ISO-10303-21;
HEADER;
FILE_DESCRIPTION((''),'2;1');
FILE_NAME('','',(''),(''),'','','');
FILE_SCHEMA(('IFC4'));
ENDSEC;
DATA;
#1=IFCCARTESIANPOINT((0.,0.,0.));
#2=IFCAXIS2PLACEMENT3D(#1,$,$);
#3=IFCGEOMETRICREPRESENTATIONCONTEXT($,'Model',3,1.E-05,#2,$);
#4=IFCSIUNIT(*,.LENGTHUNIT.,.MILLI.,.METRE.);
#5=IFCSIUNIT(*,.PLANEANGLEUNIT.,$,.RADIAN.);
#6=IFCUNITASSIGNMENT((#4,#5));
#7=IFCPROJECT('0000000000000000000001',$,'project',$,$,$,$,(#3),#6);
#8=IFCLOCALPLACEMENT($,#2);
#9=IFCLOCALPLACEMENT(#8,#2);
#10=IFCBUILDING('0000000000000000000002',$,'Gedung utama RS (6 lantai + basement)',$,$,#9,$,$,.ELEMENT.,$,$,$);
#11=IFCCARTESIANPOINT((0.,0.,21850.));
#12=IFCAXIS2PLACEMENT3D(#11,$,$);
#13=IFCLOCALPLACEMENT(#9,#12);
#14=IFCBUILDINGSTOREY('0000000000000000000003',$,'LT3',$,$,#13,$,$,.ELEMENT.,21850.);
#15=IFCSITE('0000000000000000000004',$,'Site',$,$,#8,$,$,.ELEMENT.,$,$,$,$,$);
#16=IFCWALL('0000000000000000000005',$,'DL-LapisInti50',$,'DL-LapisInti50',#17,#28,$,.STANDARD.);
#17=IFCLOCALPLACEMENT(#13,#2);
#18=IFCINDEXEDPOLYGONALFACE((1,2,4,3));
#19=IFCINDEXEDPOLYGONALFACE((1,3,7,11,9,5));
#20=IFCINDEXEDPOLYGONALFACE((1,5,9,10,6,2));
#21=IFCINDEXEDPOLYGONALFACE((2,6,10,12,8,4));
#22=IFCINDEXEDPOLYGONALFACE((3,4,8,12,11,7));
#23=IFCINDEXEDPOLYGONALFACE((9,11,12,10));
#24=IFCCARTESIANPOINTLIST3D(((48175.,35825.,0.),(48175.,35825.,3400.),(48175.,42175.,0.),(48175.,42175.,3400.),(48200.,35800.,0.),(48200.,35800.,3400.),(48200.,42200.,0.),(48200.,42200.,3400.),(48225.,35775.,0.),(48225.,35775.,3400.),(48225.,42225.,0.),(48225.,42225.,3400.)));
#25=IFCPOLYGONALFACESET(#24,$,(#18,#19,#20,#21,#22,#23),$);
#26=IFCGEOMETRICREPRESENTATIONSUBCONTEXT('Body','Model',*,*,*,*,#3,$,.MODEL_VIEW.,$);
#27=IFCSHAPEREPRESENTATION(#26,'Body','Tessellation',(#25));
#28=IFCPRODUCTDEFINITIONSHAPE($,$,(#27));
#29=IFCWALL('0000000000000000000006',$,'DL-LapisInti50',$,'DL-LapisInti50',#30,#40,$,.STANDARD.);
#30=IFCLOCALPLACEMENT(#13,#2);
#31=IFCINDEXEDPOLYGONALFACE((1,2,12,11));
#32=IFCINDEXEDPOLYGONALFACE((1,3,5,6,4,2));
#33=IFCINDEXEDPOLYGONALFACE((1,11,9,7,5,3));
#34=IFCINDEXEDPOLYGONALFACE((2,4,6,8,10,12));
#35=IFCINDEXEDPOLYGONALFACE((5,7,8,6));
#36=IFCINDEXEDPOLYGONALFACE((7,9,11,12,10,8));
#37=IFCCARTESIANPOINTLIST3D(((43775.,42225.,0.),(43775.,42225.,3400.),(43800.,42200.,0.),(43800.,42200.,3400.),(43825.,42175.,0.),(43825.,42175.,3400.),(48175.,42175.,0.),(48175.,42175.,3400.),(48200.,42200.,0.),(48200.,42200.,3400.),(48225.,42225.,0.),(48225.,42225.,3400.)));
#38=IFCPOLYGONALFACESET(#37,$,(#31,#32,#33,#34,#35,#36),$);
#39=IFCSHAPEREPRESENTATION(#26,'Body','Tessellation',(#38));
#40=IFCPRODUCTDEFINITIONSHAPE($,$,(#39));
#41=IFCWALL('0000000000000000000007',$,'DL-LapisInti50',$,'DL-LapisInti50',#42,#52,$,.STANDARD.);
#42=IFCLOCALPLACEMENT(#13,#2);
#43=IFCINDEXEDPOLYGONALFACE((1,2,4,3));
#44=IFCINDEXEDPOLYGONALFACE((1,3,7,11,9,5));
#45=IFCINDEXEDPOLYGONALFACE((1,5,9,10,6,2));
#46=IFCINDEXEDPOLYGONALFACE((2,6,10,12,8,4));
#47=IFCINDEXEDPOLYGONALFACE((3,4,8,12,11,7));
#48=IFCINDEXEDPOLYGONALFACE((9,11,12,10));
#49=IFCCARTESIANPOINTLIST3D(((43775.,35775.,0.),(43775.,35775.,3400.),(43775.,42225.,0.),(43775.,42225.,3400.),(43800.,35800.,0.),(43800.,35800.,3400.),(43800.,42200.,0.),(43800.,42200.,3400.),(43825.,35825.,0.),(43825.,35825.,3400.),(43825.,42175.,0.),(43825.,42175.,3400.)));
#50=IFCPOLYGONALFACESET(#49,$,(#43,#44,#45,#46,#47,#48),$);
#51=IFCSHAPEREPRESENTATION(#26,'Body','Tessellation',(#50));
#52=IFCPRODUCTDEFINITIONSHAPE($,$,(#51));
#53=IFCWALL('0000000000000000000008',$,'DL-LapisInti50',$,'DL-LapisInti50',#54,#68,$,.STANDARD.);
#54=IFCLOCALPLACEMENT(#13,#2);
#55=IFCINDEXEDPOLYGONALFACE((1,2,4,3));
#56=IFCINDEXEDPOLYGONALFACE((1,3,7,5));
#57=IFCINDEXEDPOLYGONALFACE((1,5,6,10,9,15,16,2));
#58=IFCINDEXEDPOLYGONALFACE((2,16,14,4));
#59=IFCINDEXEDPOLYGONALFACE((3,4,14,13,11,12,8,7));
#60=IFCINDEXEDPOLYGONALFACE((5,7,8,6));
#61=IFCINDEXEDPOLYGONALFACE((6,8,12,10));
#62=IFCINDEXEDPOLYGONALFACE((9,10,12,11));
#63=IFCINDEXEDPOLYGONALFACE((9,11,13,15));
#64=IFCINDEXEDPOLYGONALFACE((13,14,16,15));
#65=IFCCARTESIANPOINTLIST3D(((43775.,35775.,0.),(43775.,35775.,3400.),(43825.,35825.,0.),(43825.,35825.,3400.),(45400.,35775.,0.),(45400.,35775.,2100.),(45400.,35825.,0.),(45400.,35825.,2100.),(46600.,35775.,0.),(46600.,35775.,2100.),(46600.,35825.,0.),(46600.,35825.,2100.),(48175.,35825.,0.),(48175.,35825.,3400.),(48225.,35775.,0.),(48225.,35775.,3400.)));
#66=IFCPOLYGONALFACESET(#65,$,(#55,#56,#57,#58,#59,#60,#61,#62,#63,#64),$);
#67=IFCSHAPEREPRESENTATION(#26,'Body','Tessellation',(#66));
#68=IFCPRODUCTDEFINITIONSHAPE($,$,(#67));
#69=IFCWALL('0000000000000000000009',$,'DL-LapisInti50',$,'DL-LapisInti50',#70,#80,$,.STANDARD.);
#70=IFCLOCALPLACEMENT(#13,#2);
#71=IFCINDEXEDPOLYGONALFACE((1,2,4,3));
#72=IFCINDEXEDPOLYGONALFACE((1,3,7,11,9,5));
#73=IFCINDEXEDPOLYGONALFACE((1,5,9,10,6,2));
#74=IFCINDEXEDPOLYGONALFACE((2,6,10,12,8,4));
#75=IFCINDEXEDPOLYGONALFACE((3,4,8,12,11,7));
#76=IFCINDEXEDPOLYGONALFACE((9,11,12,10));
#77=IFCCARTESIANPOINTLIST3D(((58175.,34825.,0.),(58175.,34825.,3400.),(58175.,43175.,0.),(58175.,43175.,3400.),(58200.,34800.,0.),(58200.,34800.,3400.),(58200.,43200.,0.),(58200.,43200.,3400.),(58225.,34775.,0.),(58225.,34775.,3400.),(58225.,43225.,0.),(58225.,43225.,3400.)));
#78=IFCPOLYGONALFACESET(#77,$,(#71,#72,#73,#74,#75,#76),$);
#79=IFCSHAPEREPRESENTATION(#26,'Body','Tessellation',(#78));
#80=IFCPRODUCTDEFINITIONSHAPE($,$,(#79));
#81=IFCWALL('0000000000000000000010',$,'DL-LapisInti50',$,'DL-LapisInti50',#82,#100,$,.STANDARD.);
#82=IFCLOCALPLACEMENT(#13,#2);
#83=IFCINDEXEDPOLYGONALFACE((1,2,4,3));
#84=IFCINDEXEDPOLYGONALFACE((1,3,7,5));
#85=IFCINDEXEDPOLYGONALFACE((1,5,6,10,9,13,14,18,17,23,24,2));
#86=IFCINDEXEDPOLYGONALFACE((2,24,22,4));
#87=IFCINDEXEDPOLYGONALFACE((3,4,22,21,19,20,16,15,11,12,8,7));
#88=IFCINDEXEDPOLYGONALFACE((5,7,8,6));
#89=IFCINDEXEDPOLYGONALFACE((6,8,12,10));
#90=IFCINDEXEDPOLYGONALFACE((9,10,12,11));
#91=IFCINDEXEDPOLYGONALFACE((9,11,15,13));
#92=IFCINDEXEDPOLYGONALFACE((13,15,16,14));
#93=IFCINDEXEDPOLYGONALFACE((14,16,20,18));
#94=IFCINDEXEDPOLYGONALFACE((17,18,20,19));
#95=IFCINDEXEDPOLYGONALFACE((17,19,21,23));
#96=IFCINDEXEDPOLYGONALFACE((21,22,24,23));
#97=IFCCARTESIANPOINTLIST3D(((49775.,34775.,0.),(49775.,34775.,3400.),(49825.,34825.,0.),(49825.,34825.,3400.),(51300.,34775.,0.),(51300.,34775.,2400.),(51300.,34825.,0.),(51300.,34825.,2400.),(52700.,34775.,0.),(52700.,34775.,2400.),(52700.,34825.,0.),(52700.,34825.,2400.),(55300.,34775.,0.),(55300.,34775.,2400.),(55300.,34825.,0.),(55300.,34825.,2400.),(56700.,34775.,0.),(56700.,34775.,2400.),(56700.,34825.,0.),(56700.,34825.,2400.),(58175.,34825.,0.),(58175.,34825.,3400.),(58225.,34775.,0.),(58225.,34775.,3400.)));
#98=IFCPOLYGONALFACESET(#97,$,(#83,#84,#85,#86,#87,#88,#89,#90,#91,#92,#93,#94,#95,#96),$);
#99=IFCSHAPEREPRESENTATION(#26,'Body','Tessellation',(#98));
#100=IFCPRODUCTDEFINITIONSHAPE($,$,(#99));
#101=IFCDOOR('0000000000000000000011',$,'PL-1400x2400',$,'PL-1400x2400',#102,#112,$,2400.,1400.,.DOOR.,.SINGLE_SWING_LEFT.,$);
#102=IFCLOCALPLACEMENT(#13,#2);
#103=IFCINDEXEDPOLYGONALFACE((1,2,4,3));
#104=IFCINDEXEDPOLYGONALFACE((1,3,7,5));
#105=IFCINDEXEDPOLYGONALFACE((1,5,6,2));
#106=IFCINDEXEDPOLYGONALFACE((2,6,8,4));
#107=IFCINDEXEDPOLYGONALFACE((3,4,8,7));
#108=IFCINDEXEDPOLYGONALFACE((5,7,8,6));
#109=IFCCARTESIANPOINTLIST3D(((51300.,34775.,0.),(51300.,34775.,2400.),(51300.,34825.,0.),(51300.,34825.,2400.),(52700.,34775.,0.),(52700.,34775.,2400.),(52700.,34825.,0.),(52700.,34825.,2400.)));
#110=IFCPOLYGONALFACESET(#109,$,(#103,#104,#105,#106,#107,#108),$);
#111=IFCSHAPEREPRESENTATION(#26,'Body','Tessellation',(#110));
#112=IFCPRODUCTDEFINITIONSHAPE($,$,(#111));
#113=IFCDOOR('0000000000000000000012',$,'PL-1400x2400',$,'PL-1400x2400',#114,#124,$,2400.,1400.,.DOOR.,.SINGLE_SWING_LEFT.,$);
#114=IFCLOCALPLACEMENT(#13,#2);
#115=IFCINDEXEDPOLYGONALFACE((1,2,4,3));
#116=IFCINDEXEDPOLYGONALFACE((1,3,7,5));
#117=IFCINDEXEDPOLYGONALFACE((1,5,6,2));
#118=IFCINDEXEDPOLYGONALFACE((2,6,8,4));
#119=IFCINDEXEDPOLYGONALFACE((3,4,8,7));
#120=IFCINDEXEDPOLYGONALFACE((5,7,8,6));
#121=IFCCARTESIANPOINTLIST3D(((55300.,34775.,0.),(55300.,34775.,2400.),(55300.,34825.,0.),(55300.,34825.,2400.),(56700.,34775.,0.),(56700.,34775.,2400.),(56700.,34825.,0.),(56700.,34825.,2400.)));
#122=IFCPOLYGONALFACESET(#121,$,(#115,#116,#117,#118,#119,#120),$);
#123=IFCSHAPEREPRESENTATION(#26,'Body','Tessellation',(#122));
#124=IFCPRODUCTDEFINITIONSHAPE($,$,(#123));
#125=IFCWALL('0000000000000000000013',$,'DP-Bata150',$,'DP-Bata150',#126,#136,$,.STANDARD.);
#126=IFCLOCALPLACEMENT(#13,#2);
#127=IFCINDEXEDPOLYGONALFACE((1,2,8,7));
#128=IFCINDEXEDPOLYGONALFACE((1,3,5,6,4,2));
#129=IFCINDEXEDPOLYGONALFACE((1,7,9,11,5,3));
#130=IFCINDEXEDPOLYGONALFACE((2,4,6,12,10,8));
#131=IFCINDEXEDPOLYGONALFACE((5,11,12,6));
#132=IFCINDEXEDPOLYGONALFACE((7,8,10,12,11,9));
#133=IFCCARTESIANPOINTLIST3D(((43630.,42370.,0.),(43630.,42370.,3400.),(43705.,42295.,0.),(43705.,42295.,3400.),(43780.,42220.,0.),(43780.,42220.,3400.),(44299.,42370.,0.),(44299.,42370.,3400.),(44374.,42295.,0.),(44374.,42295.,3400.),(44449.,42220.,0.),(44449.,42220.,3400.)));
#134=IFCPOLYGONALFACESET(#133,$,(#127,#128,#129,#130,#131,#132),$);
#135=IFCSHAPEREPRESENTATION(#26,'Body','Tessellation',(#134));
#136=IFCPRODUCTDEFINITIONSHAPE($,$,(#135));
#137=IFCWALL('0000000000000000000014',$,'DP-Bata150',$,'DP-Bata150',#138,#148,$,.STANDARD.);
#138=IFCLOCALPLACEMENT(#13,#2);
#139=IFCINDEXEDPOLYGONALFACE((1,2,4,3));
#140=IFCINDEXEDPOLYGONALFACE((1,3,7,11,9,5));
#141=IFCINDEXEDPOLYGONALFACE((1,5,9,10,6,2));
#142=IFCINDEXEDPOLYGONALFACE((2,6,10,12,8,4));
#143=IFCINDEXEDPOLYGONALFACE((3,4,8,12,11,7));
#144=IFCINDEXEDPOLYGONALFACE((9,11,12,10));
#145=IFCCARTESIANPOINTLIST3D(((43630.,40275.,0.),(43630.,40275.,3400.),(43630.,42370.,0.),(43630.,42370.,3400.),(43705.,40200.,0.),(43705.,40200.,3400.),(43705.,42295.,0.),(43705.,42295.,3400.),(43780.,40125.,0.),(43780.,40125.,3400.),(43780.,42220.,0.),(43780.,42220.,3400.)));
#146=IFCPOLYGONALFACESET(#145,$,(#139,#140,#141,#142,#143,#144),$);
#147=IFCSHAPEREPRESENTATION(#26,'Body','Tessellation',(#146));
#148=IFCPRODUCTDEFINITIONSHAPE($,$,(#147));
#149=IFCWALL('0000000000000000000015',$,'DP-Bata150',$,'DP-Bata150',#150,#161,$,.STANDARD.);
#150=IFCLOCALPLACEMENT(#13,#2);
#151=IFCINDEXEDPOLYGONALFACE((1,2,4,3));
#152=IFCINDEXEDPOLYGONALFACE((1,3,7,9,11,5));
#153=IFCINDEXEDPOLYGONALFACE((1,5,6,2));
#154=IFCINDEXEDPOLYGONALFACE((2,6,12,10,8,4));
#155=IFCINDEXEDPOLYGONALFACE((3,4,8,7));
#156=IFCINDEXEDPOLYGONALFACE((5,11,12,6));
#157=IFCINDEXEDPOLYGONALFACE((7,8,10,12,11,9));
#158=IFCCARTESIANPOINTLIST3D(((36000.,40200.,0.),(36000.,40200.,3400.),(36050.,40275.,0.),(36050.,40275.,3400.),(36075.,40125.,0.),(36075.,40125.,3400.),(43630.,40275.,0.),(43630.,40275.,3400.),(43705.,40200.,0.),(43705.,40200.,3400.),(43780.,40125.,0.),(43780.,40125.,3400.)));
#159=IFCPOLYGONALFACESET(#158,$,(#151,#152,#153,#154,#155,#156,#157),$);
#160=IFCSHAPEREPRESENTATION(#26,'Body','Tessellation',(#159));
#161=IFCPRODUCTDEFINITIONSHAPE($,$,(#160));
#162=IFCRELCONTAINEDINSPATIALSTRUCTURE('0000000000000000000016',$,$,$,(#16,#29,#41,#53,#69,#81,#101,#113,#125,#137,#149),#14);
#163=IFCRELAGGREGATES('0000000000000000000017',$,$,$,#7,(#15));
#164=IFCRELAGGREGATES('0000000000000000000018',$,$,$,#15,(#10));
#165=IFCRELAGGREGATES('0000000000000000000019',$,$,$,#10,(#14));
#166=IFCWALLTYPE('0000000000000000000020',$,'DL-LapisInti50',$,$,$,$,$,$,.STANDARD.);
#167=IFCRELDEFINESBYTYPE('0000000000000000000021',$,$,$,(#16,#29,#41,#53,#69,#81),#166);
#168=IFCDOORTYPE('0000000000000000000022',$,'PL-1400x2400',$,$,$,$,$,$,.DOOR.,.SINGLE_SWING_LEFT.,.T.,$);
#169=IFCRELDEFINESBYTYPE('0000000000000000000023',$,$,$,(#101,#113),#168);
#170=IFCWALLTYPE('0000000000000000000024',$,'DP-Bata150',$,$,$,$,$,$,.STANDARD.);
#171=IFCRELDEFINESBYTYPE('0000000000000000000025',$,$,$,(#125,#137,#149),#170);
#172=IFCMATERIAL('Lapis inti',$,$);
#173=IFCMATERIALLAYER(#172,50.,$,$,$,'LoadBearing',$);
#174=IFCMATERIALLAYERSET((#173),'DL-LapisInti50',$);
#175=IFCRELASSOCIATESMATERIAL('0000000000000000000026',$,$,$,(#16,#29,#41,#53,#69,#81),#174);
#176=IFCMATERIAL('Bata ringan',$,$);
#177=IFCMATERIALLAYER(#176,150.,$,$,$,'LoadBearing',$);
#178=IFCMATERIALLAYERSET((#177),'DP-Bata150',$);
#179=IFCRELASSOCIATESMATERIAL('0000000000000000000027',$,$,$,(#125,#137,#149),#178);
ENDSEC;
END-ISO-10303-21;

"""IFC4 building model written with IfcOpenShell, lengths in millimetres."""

from ifc_helpers import new_model, si_unit, frame, frame_2d, origin, place, context, subcontext, project, spatial, polyline, rectangle, outline, extrude, material, layer, layer_set, layer_usage, type_object, element, fill, save


model = new_model("IFC4")

# Units and contexts
model_context = context("Model", 3, precision=1e-05, world=origin())
body_context = subcontext(model_context, "Body", "Model", "MODEL_VIEW")
ifc_project = project(units=[si_unit("LENGTHUNIT", "METRE", prefix="MILLI"), si_unit("PLANEANGLEUNIT", "RADIAN")], contexts=[model_context])

# Site, building, storey
site_placement = place(None, origin())
site = spatial("IfcSite", under=ifc_project, at=site_placement, Name="Site", CompositionType="ELEMENT")
building_placement = place(site_placement, origin())
building = spatial("IfcBuilding", under=site, at=building_placement, Name="Gedung utama RS (6 lantai + basement)", CompositionType="ELEMENT")
storey_placement = place(building_placement, frame((0.0, 0.0, 21850.0)))
storey = spatial("IfcBuildingStorey", under=building, at=storey_placement, Name="LT3", CompositionType="ELEMENT", Elevation=21850.0)

# Walls
ifc_material_1 = material(Name="Lapis inti")
ifc_layer_1 = layer(ifc_material_1, 50.0, Category="LoadBearing")
ifc_layer_set_1 = layer_set([ifc_layer_1], Name="DL-LapisInti50")
ifc_layer_usage_1 = layer_usage(ifc_layer_set_1, "AXIS2", "NEGATIVE", 25.0)
wall_type_1 = type_object("IfcWallType", Name="DL-LapisInti50", PredefinedType="STANDARD")
wall_1_placement = place(storey_placement, frame((48200.0, 35800.0, 0.0), z_axis=(0.0, 0.0, 1.0), x_axis=(0.0, 1.0, 0.0)))
element("IfcWall", 1, at=wall_1_placement, inside=storey, type_object=wall_type_1, material=ifc_layer_usage_1, Name="DL-LapisInti50", ObjectType="DL-LapisInti50", PredefinedType="STANDARD", context=body_context, shape_type="SweptSolid", body=[
    extrude(outline(polyline([(-25.0, -25.0), (0.0, 0.0), (25.0, 25.0), (6375.0, 25.0), (6400.0, 0.0), (6425.0, -25.0), (-25.0, -25.0)])), origin(), (0.0, 0.0, 1.0), 3400.0),
])
wall_2_placement = place(storey_placement, frame((48200.0, 42200.0, 0.0), z_axis=(0.0, 0.0, 1.0), x_axis=(-1.0, 0.0, 0.0)))
element("IfcWall", 2, at=wall_2_placement, inside=storey, type_object=wall_type_1, material=ifc_layer_usage_1, Name="DL-LapisInti50", ObjectType="DL-LapisInti50", PredefinedType="STANDARD", context=body_context, shape_type="SweptSolid", body=[
    extrude(outline(polyline([(-25.0, -25.0), (0.0, 0.0), (25.0, 25.0), (4375.0, 25.0), (4400.0, 0.0), (4425.0, -25.0), (-25.0, -25.0)])), origin(), (0.0, 0.0, 1.0), 3400.0),
])
wall_3_placement = place(storey_placement, frame((43800.0, 42200.0, 0.0), z_axis=(0.0, 0.0, 1.0), x_axis=(0.0, -1.0, 0.0)))
element("IfcWall", 3, at=wall_3_placement, inside=storey, type_object=wall_type_1, material=ifc_layer_usage_1, Name="DL-LapisInti50", ObjectType="DL-LapisInti50", PredefinedType="STANDARD", context=body_context, shape_type="SweptSolid", body=[
    extrude(outline(polyline([(-25.0, -25.0), (0.0, 0.0), (25.0, 25.0), (6375.0, 25.0), (6400.0, 0.0), (6425.0, -25.0), (-25.0, -25.0)])), origin(), (0.0, 0.0, 1.0), 3400.0),
])

# Wall, opening
wall_4_placement = place(storey_placement, frame((43800.0, 35800.0, 0.0), z_axis=(0.0, 0.0, 1.0), x_axis=(1.0, 0.0, 0.0)))
wall_4 = element("IfcWall", 4, at=wall_4_placement, inside=storey, type_object=wall_type_1, material=ifc_layer_usage_1, Name="DL-LapisInti50", ObjectType="DL-LapisInti50", PredefinedType="STANDARD", context=body_context, shape_type="SweptSolid", body=[
    extrude(outline(polyline([(-25.0, -25.0), (0.0, 0.0), (25.0, 25.0), (4375.0, 25.0), (4400.0, 0.0), (4425.0, -25.0), (-25.0, -25.0)])), origin(), (0.0, 0.0, 1.0), 3400.0),
])
opening_1_placement = place(wall_4_placement, frame((1600.0, 0.0, 0.0), z_axis=(0.0, 0.0, 1.0), x_axis=(1.0, 0.0, 0.0)))
element("IfcOpeningElement", 5, at=opening_1_placement, cuts=wall_4, PredefinedType="OPENING", context=body_context, shape_type="SweptSolid", body=[
    extrude(rectangle(XDim=1200.0, YDim=70.0, at=frame_2d((600.0, 0.0))), origin(), (0.0, 0.0, 1.0), 2100.0),
])

# Wall
wall_5_placement = place(storey_placement, frame((58200.0, 34800.0, 0.0), z_axis=(0.0, 0.0, 1.0), x_axis=(0.0, 1.0, 0.0)))
element("IfcWall", 6, at=wall_5_placement, inside=storey, type_object=wall_type_1, material=ifc_layer_usage_1, Name="DL-LapisInti50", ObjectType="DL-LapisInti50", PredefinedType="STANDARD", context=body_context, shape_type="SweptSolid", body=[
    extrude(outline(polyline([(-25.0, -25.0), (0.0, 0.0), (25.0, 25.0), (8375.0, 25.0), (8400.0, 0.0), (8425.0, -25.0), (-25.0, -25.0)])), origin(), (0.0, 0.0, 1.0), 3400.0),
])

# Wall, openings, doors
wall_6_placement = place(storey_placement, frame((49800.0, 34800.0, 0.0), z_axis=(0.0, 0.0, 1.0), x_axis=(1.0, 0.0, 0.0)))
wall_6 = element("IfcWall", 7, at=wall_6_placement, inside=storey, type_object=wall_type_1, material=ifc_layer_usage_1, Name="DL-LapisInti50", ObjectType="DL-LapisInti50", PredefinedType="STANDARD", context=body_context, shape_type="SweptSolid", body=[
    extrude(outline(polyline([(-25.0, -25.0), (0.0, 0.0), (25.0, 25.0), (8375.0, 25.0), (8400.0, 0.0), (8425.0, -25.0), (-25.0, -25.0)])), origin(), (0.0, 0.0, 1.0), 3400.0),
])
opening_2_placement = place(wall_6_placement, frame((1500.0, 0.0, 0.0), z_axis=(0.0, 0.0, 1.0), x_axis=(1.0, 0.0, 0.0)))
opening_2 = element("IfcOpeningElement", 8, at=opening_2_placement, cuts=wall_6, PredefinedType="OPENING", context=body_context, shape_type="SweptSolid", body=[
    extrude(rectangle(XDim=1400.0, YDim=70.0, at=frame_2d((700.0, 0.0))), origin(), (0.0, 0.0, 1.0), 2400.0),
])
opening_3_placement = place(wall_6_placement, frame((5500.0, 0.0, 0.0), z_axis=(0.0, 0.0, 1.0), x_axis=(1.0, 0.0, 0.0)))
opening_3 = element("IfcOpeningElement", 9, at=opening_3_placement, cuts=wall_6, PredefinedType="OPENING", context=body_context, shape_type="SweptSolid", body=[
    extrude(rectangle(XDim=1400.0, YDim=70.0, at=frame_2d((700.0, 0.0))), origin(), (0.0, 0.0, 1.0), 2400.0),
])
door_type = type_object("IfcDoorType", Name="PL-1400x2400", OperationType="SINGLE_SWING_LEFT", ParameterTakesPrecedence=True, PredefinedType="DOOR")
door_1_placement = place(opening_2_placement, origin())
door_1 = element("IfcDoor", 10, at=door_1_placement, inside=storey, type_object=door_type, Name="PL-1400x2400", ObjectType="PL-1400x2400", OperationType="SINGLE_SWING_LEFT", OverallHeight=2400.0, OverallWidth=1400.0, PredefinedType="DOOR", context=body_context, shape_type="SweptSolid", body=[
    extrude(rectangle(XDim=1400.0, YDim=50.0, at=frame_2d((700.0, 0.0))), origin(), (0.0, 0.0, 1.0), 2400.0),
])
fill(opening_2, door_1)
door_2_placement = place(opening_3_placement, origin())
door_2 = element("IfcDoor", 11, at=door_2_placement, inside=storey, type_object=door_type, Name="PL-1400x2400", ObjectType="PL-1400x2400", OperationType="SINGLE_SWING_LEFT", OverallHeight=2400.0, OverallWidth=1400.0, PredefinedType="DOOR", context=body_context, shape_type="SweptSolid", body=[
    extrude(rectangle(XDim=1400.0, YDim=50.0, at=frame_2d((700.0, 0.0))), origin(), (0.0, 0.0, 1.0), 2400.0),
])
fill(opening_3, door_2)

# Walls
ifc_material_2 = material(Name="Bata ringan")
ifc_layer_2 = layer(ifc_material_2, 150.0, Category="LoadBearing")
ifc_layer_set_2 = layer_set([ifc_layer_2], Name="DP-Bata150")
ifc_layer_usage_2 = layer_usage(ifc_layer_set_2, "AXIS2", "NEGATIVE", 75.0)
wall_type_2 = type_object("IfcWallType", Name="DP-Bata150", PredefinedType="STANDARD")
wall_7_placement = place(storey_placement, frame((44374.0, 42295.0, 0.0), z_axis=(0.0, 0.0, 1.0), x_axis=(-1.0, 0.0, 0.0)))
element("IfcWall", 12, at=wall_7_placement, inside=storey, type_object=wall_type_2, material=ifc_layer_usage_2, Name="DP-Bata150", ObjectType="DP-Bata150", PredefinedType="STANDARD", context=body_context, shape_type="SweptSolid", body=[
    extrude(outline(polyline([(75.0, -75.0), (0.0, 0.0), (-75.0, 75.0), (594.0, 75.0), (669.0, 0.0), (744.0, -75.0), (75.0, -75.0)])), origin(), (0.0, 0.0, 1.0), 3400.0),
])
wall_8_placement = place(storey_placement, frame((43705.0, 42295.0, 0.0), z_axis=(0.0, 0.0, 1.0), x_axis=(0.0, -1.0, 0.0)))
element("IfcWall", 13, at=wall_8_placement, inside=storey, type_object=wall_type_2, material=ifc_layer_usage_2, Name="DP-Bata150", ObjectType="DP-Bata150", PredefinedType="STANDARD", context=body_context, shape_type="SweptSolid", body=[
    extrude(outline(polyline([(-75.0, -75.0), (0.0, 0.0), (75.0, 75.0), (2170.0, 75.0), (2095.0, 0.0), (2020.0, -75.0), (-75.0, -75.0)])), origin(), (0.0, 0.0, 1.0), 3400.0),
])
wall_9_placement = place(storey_placement, frame((43705.0, 40200.0, 0.0), z_axis=(0.0, 0.0, 1.0), x_axis=(-1.0, 0.0, 0.0)))
element("IfcWall", 14, at=wall_9_placement, inside=storey, type_object=wall_type_2, material=ifc_layer_usage_2, Name="DP-Bata150", ObjectType="DP-Bata150", PredefinedType="STANDARD", context=body_context, shape_type="SweptSolid", body=[
    extrude(outline(polyline([(75.0, -75.0), (0.0, 0.0), (-75.0, 75.0), (7630.0, 75.0), (7705.0, 0.0), (7655.0, -75.0), (75.0, -75.0)])), origin(), (0.0, 0.0, 1.0), 3400.0),
])

save(model, "model.ifc")
